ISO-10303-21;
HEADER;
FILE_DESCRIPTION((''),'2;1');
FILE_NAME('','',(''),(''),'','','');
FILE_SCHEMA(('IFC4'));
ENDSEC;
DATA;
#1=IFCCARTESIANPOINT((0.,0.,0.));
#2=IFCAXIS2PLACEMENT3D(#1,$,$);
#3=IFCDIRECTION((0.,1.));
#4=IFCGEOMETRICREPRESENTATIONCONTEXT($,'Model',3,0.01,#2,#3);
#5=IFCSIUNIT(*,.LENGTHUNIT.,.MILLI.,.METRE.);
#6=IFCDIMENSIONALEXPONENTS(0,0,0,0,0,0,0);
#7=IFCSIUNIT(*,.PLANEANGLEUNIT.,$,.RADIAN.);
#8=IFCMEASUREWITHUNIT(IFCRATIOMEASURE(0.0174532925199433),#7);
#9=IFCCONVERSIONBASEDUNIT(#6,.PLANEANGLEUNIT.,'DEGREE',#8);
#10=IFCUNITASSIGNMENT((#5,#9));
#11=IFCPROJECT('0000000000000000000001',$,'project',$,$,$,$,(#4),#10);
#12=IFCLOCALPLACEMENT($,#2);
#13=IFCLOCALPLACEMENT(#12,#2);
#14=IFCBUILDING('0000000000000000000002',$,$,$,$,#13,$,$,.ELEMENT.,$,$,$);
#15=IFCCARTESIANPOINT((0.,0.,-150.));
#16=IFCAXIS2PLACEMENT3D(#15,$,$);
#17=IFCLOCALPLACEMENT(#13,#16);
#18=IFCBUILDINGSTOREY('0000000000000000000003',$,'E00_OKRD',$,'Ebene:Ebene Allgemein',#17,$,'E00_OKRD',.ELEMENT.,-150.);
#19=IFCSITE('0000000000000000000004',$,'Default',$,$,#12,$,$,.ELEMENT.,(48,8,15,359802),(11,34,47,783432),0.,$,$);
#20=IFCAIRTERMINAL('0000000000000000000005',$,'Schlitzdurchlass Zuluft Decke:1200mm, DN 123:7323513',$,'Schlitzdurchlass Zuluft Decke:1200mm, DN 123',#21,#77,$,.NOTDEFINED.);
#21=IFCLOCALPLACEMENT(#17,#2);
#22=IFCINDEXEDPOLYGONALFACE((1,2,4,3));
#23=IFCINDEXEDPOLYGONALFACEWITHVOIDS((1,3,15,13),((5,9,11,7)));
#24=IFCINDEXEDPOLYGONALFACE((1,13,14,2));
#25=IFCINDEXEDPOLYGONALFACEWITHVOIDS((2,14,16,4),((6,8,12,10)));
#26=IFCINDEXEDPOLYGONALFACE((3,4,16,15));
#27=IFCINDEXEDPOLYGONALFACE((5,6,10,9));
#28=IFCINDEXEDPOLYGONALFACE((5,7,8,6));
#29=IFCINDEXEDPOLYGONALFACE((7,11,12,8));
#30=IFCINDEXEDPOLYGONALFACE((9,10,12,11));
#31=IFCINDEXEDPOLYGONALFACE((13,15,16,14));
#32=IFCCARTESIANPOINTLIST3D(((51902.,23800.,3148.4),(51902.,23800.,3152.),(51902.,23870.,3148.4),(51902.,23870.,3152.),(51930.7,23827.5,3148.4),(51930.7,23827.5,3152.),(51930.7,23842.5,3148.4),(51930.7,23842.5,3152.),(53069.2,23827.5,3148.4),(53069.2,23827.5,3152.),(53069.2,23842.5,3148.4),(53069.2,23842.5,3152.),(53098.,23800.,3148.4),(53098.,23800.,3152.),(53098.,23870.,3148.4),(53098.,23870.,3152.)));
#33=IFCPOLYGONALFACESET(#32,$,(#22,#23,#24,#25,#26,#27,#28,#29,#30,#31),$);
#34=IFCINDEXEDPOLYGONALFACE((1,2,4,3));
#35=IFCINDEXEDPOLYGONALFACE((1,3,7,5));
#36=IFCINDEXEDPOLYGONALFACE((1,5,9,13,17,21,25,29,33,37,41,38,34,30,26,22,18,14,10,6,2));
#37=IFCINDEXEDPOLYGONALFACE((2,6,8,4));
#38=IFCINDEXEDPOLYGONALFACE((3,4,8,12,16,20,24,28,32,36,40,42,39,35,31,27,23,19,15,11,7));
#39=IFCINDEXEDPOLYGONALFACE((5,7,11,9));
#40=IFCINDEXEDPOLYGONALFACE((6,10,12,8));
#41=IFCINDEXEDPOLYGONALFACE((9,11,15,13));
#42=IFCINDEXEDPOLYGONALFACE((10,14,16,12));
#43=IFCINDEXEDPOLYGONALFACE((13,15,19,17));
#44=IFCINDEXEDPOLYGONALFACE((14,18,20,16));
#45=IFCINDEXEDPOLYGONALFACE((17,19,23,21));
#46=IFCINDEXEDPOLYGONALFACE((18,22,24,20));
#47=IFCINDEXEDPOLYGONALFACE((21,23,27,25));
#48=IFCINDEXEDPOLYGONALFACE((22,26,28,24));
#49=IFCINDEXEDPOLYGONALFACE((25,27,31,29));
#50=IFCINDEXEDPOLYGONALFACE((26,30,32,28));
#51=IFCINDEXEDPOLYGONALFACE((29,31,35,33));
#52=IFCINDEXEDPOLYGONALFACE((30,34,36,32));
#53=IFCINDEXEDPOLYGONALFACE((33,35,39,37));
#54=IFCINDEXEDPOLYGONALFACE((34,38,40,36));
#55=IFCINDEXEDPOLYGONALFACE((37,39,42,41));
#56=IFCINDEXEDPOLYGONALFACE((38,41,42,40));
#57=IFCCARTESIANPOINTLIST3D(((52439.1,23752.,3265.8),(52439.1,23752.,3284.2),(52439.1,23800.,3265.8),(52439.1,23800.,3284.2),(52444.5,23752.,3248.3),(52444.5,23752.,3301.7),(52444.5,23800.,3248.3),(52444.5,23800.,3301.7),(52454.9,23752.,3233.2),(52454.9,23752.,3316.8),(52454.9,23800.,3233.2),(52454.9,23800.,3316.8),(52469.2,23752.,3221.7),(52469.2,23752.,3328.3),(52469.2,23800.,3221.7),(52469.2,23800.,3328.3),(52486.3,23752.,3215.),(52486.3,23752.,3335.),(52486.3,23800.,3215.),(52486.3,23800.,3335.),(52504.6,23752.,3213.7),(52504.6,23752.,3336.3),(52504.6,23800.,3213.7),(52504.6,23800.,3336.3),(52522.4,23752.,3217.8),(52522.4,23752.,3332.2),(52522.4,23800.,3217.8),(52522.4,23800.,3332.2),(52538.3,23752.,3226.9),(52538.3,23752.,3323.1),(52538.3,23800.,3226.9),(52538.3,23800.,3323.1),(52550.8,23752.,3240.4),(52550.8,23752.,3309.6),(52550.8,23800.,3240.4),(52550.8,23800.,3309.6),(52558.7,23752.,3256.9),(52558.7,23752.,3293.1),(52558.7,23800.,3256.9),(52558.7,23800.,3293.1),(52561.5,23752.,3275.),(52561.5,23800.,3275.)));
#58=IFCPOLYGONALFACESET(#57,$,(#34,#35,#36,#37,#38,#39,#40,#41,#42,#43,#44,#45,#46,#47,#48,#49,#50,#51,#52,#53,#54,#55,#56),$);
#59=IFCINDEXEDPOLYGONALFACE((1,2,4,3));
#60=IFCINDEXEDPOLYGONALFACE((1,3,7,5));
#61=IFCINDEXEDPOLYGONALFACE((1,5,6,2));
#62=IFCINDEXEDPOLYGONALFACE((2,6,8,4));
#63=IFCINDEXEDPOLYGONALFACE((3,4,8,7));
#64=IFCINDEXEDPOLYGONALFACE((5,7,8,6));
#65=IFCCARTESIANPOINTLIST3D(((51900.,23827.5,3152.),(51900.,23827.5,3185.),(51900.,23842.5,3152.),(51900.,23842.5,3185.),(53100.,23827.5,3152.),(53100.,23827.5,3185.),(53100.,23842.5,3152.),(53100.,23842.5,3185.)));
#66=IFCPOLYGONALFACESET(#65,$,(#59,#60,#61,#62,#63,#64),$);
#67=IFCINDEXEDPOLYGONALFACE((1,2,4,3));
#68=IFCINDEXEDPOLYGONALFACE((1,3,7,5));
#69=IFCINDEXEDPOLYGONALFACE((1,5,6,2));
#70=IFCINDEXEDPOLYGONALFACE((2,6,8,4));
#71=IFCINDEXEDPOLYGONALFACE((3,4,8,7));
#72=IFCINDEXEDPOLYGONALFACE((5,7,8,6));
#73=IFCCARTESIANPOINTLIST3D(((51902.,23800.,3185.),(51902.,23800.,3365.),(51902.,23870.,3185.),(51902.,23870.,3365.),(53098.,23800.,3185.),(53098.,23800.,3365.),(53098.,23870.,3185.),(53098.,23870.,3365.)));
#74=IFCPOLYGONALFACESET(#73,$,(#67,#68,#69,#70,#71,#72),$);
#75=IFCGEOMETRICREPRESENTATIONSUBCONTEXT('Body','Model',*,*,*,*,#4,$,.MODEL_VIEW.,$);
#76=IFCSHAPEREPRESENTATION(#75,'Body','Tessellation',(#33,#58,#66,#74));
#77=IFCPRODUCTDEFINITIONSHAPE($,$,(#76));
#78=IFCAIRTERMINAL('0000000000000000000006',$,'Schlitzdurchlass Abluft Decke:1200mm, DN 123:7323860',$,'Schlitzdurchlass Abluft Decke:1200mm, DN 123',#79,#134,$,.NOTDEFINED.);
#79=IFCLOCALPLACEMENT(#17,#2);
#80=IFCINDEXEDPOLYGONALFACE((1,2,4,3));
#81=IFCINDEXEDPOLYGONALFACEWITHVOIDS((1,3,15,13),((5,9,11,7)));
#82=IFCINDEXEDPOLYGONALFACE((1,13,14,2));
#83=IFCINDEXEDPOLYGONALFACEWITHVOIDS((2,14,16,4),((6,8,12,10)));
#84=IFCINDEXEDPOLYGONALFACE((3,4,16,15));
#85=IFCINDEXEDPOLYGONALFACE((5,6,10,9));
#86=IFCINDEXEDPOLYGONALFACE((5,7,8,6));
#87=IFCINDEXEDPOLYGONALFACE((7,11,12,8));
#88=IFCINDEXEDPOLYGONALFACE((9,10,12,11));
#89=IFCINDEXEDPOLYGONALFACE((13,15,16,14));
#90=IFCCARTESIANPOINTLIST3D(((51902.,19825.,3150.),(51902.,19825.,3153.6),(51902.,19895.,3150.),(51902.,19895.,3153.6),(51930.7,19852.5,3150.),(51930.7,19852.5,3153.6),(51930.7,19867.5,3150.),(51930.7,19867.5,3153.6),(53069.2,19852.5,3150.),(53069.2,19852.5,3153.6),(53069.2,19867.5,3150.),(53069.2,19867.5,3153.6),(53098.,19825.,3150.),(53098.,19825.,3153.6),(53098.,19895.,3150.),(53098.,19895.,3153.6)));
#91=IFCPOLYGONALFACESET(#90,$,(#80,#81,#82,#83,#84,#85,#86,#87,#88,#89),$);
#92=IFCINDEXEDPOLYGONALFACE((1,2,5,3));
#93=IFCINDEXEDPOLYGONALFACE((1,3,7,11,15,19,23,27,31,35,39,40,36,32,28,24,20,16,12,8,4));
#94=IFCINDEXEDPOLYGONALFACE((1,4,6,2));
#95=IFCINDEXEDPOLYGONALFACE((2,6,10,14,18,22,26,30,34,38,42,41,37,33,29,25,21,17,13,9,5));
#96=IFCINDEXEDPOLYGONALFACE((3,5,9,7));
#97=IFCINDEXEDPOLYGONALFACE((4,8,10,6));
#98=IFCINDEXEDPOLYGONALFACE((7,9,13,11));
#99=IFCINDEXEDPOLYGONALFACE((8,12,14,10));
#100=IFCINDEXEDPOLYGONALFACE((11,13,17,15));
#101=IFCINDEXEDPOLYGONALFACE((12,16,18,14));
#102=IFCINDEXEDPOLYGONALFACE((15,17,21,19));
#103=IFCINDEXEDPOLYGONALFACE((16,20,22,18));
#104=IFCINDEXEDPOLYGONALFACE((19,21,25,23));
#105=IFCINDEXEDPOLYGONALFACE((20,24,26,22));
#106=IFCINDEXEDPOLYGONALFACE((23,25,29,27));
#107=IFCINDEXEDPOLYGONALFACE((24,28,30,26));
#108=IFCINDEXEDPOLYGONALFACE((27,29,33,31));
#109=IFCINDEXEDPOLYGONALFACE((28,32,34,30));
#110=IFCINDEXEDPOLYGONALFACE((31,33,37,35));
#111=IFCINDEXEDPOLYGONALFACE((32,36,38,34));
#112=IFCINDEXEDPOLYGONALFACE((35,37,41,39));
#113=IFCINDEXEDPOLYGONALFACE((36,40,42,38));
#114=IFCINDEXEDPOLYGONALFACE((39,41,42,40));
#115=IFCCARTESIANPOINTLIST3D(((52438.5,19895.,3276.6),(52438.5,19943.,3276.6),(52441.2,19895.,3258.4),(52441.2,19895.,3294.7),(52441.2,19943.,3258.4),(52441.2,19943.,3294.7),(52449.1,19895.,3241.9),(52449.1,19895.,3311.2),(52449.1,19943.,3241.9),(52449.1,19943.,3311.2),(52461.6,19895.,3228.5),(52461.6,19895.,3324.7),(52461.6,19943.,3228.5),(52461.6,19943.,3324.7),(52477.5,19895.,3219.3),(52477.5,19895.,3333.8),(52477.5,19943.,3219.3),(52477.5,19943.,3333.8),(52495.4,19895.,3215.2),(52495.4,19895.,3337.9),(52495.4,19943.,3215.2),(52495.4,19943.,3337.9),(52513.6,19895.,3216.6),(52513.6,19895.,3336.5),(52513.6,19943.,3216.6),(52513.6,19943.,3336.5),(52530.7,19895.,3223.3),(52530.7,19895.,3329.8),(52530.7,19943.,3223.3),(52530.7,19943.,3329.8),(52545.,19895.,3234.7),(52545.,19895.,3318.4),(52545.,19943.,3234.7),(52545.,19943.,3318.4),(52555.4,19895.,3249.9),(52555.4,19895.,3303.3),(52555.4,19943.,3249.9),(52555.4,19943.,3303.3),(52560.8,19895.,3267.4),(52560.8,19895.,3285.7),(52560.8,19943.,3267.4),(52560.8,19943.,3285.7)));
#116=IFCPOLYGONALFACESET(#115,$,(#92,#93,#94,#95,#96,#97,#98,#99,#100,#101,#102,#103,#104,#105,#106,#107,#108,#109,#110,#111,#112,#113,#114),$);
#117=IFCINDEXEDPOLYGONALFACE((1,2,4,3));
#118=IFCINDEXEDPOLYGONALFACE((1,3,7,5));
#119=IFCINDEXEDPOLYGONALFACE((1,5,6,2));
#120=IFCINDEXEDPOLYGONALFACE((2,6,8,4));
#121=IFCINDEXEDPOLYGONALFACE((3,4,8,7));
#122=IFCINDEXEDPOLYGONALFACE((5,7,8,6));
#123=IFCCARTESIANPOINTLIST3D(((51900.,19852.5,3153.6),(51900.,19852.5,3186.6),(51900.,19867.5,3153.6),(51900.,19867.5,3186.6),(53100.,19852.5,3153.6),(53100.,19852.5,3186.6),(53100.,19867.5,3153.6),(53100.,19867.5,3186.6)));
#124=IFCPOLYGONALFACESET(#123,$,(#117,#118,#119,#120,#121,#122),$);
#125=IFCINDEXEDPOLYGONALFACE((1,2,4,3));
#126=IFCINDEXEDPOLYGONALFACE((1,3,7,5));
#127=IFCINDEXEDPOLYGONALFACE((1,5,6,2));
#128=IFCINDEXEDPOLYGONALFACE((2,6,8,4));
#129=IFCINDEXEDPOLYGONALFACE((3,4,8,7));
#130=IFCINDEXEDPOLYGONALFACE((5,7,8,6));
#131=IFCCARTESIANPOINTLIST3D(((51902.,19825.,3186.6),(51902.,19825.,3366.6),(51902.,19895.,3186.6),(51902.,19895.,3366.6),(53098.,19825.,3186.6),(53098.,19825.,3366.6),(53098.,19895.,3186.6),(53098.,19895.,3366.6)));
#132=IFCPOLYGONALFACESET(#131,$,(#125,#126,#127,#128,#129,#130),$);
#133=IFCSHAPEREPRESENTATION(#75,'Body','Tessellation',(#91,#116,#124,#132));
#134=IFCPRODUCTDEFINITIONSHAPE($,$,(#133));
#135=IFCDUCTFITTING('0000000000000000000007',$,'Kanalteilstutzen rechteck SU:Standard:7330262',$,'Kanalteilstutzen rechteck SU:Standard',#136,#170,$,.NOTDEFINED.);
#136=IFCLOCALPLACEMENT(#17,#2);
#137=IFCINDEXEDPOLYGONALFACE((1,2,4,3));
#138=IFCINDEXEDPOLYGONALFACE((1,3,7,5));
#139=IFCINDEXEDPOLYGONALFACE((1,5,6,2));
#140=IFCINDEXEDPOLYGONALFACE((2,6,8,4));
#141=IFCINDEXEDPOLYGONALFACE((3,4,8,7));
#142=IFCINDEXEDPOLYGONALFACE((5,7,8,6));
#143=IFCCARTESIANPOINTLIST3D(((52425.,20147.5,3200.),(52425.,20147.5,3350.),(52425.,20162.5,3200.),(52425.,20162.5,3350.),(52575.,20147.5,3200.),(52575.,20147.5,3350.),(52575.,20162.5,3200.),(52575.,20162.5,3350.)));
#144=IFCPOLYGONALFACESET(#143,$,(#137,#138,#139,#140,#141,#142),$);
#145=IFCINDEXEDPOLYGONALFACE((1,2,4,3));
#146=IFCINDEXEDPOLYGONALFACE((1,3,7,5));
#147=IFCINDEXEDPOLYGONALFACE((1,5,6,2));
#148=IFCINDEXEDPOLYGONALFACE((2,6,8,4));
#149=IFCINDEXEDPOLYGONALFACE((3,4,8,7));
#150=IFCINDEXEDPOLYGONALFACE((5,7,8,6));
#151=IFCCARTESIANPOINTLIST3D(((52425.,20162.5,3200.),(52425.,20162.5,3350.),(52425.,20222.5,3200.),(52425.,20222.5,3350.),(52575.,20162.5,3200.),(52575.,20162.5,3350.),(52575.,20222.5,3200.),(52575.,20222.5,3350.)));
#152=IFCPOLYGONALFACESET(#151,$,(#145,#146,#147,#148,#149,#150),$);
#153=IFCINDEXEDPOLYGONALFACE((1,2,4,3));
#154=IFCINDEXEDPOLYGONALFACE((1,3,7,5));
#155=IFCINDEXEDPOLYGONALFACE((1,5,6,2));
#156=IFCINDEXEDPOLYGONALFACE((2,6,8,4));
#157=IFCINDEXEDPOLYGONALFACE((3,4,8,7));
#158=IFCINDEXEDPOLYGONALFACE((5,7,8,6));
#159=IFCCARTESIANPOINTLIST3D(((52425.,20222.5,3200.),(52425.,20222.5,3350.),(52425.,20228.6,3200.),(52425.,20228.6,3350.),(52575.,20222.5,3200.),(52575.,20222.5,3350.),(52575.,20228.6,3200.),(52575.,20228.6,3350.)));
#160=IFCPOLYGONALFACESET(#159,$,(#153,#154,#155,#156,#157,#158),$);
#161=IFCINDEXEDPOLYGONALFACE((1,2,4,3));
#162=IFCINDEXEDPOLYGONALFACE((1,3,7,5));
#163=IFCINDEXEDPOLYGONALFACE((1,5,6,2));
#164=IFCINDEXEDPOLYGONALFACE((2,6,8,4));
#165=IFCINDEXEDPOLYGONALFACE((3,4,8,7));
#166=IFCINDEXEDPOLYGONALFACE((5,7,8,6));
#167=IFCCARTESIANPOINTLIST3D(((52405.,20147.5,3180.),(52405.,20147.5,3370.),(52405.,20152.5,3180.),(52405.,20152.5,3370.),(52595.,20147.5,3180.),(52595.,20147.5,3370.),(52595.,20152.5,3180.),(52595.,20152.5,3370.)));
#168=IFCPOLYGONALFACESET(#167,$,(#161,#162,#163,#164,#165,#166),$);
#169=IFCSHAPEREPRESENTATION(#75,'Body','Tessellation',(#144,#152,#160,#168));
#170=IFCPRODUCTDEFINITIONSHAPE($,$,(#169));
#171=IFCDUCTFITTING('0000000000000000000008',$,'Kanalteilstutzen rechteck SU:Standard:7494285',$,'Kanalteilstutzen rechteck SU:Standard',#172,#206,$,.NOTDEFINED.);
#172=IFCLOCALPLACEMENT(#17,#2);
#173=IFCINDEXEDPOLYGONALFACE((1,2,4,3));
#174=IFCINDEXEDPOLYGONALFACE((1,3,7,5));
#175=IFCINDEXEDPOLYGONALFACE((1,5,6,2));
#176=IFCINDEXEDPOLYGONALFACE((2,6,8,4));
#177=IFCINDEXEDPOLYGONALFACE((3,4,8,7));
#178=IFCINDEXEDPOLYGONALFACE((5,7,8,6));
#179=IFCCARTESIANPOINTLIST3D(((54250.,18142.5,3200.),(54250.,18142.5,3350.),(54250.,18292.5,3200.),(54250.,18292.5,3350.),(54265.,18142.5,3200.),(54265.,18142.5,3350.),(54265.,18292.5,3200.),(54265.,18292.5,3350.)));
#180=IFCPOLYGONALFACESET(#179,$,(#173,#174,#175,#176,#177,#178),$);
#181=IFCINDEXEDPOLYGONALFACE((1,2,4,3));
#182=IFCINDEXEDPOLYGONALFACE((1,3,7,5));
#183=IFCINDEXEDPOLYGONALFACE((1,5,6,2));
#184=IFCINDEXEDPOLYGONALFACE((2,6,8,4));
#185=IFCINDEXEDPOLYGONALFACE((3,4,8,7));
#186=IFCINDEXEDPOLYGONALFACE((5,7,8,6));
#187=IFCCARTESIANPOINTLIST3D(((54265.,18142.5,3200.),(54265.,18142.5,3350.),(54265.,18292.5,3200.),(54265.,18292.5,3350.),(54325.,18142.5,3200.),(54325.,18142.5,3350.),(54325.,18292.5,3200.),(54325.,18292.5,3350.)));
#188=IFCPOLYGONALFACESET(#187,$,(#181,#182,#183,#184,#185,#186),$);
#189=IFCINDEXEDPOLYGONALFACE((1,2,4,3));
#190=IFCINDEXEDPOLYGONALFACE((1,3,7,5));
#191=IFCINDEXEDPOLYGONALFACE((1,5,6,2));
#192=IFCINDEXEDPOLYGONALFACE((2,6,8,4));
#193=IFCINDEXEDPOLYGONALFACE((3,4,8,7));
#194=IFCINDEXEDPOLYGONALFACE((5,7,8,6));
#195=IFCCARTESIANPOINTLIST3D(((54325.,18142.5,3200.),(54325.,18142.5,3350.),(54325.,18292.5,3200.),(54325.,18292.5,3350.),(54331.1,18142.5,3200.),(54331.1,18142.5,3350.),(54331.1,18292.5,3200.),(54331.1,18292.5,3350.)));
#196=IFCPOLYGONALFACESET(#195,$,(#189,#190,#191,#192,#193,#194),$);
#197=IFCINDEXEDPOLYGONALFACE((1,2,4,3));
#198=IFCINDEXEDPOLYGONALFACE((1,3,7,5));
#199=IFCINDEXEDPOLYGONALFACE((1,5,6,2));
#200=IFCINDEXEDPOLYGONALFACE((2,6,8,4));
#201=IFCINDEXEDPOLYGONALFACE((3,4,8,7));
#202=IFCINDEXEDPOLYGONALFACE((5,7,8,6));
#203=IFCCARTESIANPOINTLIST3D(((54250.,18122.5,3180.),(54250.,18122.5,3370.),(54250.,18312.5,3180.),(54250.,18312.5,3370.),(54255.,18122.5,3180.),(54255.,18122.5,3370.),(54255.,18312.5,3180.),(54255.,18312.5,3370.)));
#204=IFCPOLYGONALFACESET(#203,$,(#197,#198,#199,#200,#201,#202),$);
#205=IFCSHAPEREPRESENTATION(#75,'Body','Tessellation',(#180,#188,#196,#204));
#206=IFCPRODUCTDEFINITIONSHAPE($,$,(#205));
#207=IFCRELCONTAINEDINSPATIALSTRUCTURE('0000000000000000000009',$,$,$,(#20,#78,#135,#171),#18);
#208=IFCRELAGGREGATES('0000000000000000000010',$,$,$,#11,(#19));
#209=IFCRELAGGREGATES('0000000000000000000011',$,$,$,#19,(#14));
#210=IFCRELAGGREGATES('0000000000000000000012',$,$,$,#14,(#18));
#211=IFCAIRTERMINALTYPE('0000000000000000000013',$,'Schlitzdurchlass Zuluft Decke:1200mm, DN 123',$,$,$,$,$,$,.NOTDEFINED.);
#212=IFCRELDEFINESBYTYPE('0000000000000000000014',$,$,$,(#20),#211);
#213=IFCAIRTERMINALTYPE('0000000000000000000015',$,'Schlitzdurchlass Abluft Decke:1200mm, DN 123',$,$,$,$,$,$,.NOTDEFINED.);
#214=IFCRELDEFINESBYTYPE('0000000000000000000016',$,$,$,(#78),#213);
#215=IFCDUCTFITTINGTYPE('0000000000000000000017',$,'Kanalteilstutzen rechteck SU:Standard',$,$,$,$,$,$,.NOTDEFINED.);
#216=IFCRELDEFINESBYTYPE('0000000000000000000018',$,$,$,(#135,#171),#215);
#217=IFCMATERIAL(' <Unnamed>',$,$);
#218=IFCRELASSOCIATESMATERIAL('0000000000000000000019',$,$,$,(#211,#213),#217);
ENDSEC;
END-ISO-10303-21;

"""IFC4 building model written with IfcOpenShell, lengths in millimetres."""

from ifc_helpers import new_model, entity, si_unit, converted_unit, direction, frame, frame_2d, origin, origin_2d_with_axis, place, context, subcontext, project, spatial, polyline, rectangle, circle, outline, extrude, source, transform, mapped, material, type_object, type_shapes, element, save


model = new_model("IFC4")

# Units and contexts
model_context = context("Model", 3, precision=0.01, world=origin(), true_north=direction((0.0, 1.0)))
body_context = subcontext(model_context, "Body", "Model", "MODEL_VIEW")
ifc_project = project(units=[si_unit("LENGTHUNIT", "METRE", prefix="MILLI"), converted_unit("PLANEANGLEUNIT", "DEGREE", entity("IfcRatioMeasure", 0.0174532925199433), si_unit("PLANEANGLEUNIT", "RADIAN"), dimensions=[0, 0, 0, 0, 0, 0, 0])], contexts=[model_context])

# Site, building, storey
site_placement = place(None, origin())
site = spatial("IfcSite", under=ifc_project, at=site_placement, Name="Default", CompositionType="ELEMENT", RefLatitude=(48, 8, 15, 359802), RefLongitude=(11, 34, 47, 783432), RefElevation=0.0)
building_placement = place(site_placement, origin())
building = spatial("IfcBuilding", under=site, at=building_placement, CompositionType="ELEMENT")
storey_placement = place(building_placement, frame((0.0, 0.0, -150.0)))
storey = spatial("IfcBuildingStorey", under=building, at=storey_placement, Name="E00_OKRD", ObjectType="Ebene:Ebene Allgemein", LongName="E00_OKRD", CompositionType="ELEMENT", Elevation=-150.0)

# Air terminals
ifc_material_1 = material(Name=" <Unnamed>")
air_terminal_type_1 = type_object("IfcAirTerminalType", Name="Schlitzdurchlass Zuluft Decke:1200mm, DN 123", PredefinedType="NOTDEFINED", material=ifc_material_1)
shared_shape_1 = source(origin(), body_context, "Body", "SweptSolid", [
    extrude(outline(polyline([(-598.0, -35.0), (598.0, -35.0), (598.0, 35.0), (-598.0, 35.0), (-598.0, -35.0)]), holes=[polyline([(-569.2, -7.5), (-569.2, 7.5), (569.2, 7.5), (569.2, -7.5), (-569.2, -7.5)])]), frame((600.0, 35.0, 0.0), z_axis=(0.0, 0.0, 1.0), x_axis=(-1.0, 0.0, 0.0)), (0.0, 0.0, 1.0), 3.6),
    extrude(circle(Radius=61.5, at=frame_2d((0.0, 0.0), x_axis=(1.0, 0.0))), frame((600.0, 70.0, 126.6), z_axis=(0.0, 1.0, 0.0), x_axis=(-1.0, 0.0, 0.0)), (0.0, 0.0, 1.0), 48.0),
    extrude(rectangle(XDim=1200.0, YDim=15.0, at=origin_2d_with_axis()), frame((600.0, 35.0, 3.6), z_axis=(0.0, 0.0, 1.0), x_axis=(-1.0, 0.0, 0.0)), (0.0, 0.0, 1.0), 33.0),
    extrude(rectangle(XDim=1196.0, YDim=70.0, at=origin_2d_with_axis()), frame((600.0, 35.0, 36.6), z_axis=(0.0, 0.0, 1.0), x_axis=(-1.0, 0.0, 0.0)), (0.0, 0.0, 1.0), 180.0),
])
type_shapes(air_terminal_type_1, [shared_shape_1])
air_terminal_1_placement = place(storey_placement, frame((53100.0, 23870.0, 3148.4), z_axis=(0.0, 0.0, 1.0), x_axis=(-1.0, 0.0, 0.0)))
element("IfcAirTerminal", 1, at=air_terminal_1_placement, inside=storey, type_object=air_terminal_type_1, Name="Schlitzdurchlass Zuluft Decke:1200mm, DN 123:7323513", ObjectType="Schlitzdurchlass Zuluft Decke:1200mm, DN 123", PredefinedType="NOTDEFINED", context=body_context, shape_type="MappedRepresentation", body=[
    mapped(shared_shape_1, transform((0.0, 0.0, 0.0), scale=1.0)),
])
air_terminal_type_2 = type_object("IfcAirTerminalType", Name="Schlitzdurchlass Abluft Decke:1200mm, DN 123", PredefinedType="NOTDEFINED", material=ifc_material_1)
shared_shape_2 = source(origin(), body_context, "Body", "SweptSolid", [
    extrude(outline(polyline([(-598.0, -35.0), (598.0, -35.0), (598.0, 35.0), (-598.0, 35.0), (-598.0, -35.0)]), holes=[polyline([(-569.2, -7.5), (-569.2, 7.5), (569.2, 7.5), (569.2, -7.5), (-569.2, -7.5)])]), frame((0.0, 0.0, 0.0), z_axis=(0.0, 0.0, 1.0), x_axis=(-1.0, 0.0, 0.0)), (0.0, 0.0, 1.0), 3.6),
    extrude(circle(Radius=61.5, at=frame_2d((0.0, 0.0), x_axis=(1.0, 0.0))), frame((0.0, 35.0, 126.6), z_axis=(0.0, 1.0, 0.0), x_axis=(-1.0, 0.0, 0.0)), (0.0, 0.0, 1.0), 48.0),
    extrude(rectangle(XDim=1200.0, YDim=15.0, at=origin_2d_with_axis()), frame((0.0, 0.0, 3.6), z_axis=(0.0, 0.0, 1.0), x_axis=(-1.0, 0.0, 0.0)), (0.0, 0.0, 1.0), 33.0),
    extrude(rectangle(XDim=1196.0, YDim=70.0, at=origin_2d_with_axis()), frame((0.0, 0.0, 36.6), z_axis=(0.0, 0.0, 1.0), x_axis=(-1.0, 0.0, 0.0)), (0.0, 0.0, 1.0), 180.0),
])
type_shapes(air_terminal_type_2, [shared_shape_2])
air_terminal_2_placement = place(storey_placement, frame((52500.0, 19860.0, 3150.0)))
element("IfcAirTerminal", 2, at=air_terminal_2_placement, inside=storey, type_object=air_terminal_type_2, Name="Schlitzdurchlass Abluft Decke:1200mm, DN 123:7323860", ObjectType="Schlitzdurchlass Abluft Decke:1200mm, DN 123", PredefinedType="NOTDEFINED", context=body_context, shape_type="MappedRepresentation", body=[
    mapped(shared_shape_2, transform((0.0, 0.0, 0.0), scale=1.0)),
])

# Duct fittings
duct_fitting_type_1 = type_object("IfcDuctFittingType", Name="Kanalteilstutzen rechteck SU:Standard", PredefinedType="NOTDEFINED")
shared_shape_3 = source(origin(), body_context, "Body", "SweptSolid", [
    extrude(rectangle(XDim=150.0, YDim=15.0, at=origin_2d_with_axis()), frame((67.5, 0.0, -75.0), z_axis=(0.0, 0.0, 1.0), x_axis=(0.0, -1.0, 0.0)), (0.0, 0.0, 1.0), 150.0),
    extrude(rectangle(XDim=150.0, YDim=60.0, at=frame_2d((0.0, 0.0), x_axis=(1.0, 0.0))), frame((30.0, 0.0, -75.0), z_axis=(0.0, 0.0, 1.0), x_axis=(0.0, -1.0, 0.0)), (0.0, 0.0, 1.0), 150.0),
    extrude(rectangle(XDim=150.0, YDim=6.1, at=frame_2d((0.0, 0.0), x_axis=(1.0, 0.0))), frame((-3.0, 0.0, -75.0), z_axis=(0.0, 0.0, 1.0), x_axis=(0.0, -1.0, 0.0)), (0.0, 0.0, 1.0), 150.0),
    extrude(rectangle(XDim=190.0, YDim=5.0, at=origin_2d_with_axis()), frame((72.5, 0.0, -95.0), z_axis=(0.0, 0.0, 1.0), x_axis=(0.0, -1.0, 0.0)), (0.0, 0.0, 1.0), 190.0),
])
type_shapes(duct_fitting_type_1, [shared_shape_3])
for number, where, z_axis, x_axis, name in (
    (3, (52500.0, 20222.5, 3275.0), (0.0, 0.0, -1.0), (0.0, -1.0, 0.0), "Kanalteilstutzen rechteck SU:Standard:7330262"),
    (4, (54325.0, 18217.5, 3275.0), (0.0, 0.0, -1.0), (-1.0, 0.0, 0.0), "Kanalteilstutzen rechteck SU:Standard:7494285"),
):
    element("IfcDuctFitting", number, at=place(storey_placement, frame(where, z_axis=z_axis, x_axis=x_axis)), inside=storey, type_object=duct_fitting_type_1, Name=name, ObjectType="Kanalteilstutzen rechteck SU:Standard", PredefinedType="NOTDEFINED", context=body_context, shape_type="MappedRepresentation", body=[
        mapped(shared_shape_3, transform((0.0, 0.0, 0.0), scale=1.0)),
    ])

save(model, "model.ifc")
